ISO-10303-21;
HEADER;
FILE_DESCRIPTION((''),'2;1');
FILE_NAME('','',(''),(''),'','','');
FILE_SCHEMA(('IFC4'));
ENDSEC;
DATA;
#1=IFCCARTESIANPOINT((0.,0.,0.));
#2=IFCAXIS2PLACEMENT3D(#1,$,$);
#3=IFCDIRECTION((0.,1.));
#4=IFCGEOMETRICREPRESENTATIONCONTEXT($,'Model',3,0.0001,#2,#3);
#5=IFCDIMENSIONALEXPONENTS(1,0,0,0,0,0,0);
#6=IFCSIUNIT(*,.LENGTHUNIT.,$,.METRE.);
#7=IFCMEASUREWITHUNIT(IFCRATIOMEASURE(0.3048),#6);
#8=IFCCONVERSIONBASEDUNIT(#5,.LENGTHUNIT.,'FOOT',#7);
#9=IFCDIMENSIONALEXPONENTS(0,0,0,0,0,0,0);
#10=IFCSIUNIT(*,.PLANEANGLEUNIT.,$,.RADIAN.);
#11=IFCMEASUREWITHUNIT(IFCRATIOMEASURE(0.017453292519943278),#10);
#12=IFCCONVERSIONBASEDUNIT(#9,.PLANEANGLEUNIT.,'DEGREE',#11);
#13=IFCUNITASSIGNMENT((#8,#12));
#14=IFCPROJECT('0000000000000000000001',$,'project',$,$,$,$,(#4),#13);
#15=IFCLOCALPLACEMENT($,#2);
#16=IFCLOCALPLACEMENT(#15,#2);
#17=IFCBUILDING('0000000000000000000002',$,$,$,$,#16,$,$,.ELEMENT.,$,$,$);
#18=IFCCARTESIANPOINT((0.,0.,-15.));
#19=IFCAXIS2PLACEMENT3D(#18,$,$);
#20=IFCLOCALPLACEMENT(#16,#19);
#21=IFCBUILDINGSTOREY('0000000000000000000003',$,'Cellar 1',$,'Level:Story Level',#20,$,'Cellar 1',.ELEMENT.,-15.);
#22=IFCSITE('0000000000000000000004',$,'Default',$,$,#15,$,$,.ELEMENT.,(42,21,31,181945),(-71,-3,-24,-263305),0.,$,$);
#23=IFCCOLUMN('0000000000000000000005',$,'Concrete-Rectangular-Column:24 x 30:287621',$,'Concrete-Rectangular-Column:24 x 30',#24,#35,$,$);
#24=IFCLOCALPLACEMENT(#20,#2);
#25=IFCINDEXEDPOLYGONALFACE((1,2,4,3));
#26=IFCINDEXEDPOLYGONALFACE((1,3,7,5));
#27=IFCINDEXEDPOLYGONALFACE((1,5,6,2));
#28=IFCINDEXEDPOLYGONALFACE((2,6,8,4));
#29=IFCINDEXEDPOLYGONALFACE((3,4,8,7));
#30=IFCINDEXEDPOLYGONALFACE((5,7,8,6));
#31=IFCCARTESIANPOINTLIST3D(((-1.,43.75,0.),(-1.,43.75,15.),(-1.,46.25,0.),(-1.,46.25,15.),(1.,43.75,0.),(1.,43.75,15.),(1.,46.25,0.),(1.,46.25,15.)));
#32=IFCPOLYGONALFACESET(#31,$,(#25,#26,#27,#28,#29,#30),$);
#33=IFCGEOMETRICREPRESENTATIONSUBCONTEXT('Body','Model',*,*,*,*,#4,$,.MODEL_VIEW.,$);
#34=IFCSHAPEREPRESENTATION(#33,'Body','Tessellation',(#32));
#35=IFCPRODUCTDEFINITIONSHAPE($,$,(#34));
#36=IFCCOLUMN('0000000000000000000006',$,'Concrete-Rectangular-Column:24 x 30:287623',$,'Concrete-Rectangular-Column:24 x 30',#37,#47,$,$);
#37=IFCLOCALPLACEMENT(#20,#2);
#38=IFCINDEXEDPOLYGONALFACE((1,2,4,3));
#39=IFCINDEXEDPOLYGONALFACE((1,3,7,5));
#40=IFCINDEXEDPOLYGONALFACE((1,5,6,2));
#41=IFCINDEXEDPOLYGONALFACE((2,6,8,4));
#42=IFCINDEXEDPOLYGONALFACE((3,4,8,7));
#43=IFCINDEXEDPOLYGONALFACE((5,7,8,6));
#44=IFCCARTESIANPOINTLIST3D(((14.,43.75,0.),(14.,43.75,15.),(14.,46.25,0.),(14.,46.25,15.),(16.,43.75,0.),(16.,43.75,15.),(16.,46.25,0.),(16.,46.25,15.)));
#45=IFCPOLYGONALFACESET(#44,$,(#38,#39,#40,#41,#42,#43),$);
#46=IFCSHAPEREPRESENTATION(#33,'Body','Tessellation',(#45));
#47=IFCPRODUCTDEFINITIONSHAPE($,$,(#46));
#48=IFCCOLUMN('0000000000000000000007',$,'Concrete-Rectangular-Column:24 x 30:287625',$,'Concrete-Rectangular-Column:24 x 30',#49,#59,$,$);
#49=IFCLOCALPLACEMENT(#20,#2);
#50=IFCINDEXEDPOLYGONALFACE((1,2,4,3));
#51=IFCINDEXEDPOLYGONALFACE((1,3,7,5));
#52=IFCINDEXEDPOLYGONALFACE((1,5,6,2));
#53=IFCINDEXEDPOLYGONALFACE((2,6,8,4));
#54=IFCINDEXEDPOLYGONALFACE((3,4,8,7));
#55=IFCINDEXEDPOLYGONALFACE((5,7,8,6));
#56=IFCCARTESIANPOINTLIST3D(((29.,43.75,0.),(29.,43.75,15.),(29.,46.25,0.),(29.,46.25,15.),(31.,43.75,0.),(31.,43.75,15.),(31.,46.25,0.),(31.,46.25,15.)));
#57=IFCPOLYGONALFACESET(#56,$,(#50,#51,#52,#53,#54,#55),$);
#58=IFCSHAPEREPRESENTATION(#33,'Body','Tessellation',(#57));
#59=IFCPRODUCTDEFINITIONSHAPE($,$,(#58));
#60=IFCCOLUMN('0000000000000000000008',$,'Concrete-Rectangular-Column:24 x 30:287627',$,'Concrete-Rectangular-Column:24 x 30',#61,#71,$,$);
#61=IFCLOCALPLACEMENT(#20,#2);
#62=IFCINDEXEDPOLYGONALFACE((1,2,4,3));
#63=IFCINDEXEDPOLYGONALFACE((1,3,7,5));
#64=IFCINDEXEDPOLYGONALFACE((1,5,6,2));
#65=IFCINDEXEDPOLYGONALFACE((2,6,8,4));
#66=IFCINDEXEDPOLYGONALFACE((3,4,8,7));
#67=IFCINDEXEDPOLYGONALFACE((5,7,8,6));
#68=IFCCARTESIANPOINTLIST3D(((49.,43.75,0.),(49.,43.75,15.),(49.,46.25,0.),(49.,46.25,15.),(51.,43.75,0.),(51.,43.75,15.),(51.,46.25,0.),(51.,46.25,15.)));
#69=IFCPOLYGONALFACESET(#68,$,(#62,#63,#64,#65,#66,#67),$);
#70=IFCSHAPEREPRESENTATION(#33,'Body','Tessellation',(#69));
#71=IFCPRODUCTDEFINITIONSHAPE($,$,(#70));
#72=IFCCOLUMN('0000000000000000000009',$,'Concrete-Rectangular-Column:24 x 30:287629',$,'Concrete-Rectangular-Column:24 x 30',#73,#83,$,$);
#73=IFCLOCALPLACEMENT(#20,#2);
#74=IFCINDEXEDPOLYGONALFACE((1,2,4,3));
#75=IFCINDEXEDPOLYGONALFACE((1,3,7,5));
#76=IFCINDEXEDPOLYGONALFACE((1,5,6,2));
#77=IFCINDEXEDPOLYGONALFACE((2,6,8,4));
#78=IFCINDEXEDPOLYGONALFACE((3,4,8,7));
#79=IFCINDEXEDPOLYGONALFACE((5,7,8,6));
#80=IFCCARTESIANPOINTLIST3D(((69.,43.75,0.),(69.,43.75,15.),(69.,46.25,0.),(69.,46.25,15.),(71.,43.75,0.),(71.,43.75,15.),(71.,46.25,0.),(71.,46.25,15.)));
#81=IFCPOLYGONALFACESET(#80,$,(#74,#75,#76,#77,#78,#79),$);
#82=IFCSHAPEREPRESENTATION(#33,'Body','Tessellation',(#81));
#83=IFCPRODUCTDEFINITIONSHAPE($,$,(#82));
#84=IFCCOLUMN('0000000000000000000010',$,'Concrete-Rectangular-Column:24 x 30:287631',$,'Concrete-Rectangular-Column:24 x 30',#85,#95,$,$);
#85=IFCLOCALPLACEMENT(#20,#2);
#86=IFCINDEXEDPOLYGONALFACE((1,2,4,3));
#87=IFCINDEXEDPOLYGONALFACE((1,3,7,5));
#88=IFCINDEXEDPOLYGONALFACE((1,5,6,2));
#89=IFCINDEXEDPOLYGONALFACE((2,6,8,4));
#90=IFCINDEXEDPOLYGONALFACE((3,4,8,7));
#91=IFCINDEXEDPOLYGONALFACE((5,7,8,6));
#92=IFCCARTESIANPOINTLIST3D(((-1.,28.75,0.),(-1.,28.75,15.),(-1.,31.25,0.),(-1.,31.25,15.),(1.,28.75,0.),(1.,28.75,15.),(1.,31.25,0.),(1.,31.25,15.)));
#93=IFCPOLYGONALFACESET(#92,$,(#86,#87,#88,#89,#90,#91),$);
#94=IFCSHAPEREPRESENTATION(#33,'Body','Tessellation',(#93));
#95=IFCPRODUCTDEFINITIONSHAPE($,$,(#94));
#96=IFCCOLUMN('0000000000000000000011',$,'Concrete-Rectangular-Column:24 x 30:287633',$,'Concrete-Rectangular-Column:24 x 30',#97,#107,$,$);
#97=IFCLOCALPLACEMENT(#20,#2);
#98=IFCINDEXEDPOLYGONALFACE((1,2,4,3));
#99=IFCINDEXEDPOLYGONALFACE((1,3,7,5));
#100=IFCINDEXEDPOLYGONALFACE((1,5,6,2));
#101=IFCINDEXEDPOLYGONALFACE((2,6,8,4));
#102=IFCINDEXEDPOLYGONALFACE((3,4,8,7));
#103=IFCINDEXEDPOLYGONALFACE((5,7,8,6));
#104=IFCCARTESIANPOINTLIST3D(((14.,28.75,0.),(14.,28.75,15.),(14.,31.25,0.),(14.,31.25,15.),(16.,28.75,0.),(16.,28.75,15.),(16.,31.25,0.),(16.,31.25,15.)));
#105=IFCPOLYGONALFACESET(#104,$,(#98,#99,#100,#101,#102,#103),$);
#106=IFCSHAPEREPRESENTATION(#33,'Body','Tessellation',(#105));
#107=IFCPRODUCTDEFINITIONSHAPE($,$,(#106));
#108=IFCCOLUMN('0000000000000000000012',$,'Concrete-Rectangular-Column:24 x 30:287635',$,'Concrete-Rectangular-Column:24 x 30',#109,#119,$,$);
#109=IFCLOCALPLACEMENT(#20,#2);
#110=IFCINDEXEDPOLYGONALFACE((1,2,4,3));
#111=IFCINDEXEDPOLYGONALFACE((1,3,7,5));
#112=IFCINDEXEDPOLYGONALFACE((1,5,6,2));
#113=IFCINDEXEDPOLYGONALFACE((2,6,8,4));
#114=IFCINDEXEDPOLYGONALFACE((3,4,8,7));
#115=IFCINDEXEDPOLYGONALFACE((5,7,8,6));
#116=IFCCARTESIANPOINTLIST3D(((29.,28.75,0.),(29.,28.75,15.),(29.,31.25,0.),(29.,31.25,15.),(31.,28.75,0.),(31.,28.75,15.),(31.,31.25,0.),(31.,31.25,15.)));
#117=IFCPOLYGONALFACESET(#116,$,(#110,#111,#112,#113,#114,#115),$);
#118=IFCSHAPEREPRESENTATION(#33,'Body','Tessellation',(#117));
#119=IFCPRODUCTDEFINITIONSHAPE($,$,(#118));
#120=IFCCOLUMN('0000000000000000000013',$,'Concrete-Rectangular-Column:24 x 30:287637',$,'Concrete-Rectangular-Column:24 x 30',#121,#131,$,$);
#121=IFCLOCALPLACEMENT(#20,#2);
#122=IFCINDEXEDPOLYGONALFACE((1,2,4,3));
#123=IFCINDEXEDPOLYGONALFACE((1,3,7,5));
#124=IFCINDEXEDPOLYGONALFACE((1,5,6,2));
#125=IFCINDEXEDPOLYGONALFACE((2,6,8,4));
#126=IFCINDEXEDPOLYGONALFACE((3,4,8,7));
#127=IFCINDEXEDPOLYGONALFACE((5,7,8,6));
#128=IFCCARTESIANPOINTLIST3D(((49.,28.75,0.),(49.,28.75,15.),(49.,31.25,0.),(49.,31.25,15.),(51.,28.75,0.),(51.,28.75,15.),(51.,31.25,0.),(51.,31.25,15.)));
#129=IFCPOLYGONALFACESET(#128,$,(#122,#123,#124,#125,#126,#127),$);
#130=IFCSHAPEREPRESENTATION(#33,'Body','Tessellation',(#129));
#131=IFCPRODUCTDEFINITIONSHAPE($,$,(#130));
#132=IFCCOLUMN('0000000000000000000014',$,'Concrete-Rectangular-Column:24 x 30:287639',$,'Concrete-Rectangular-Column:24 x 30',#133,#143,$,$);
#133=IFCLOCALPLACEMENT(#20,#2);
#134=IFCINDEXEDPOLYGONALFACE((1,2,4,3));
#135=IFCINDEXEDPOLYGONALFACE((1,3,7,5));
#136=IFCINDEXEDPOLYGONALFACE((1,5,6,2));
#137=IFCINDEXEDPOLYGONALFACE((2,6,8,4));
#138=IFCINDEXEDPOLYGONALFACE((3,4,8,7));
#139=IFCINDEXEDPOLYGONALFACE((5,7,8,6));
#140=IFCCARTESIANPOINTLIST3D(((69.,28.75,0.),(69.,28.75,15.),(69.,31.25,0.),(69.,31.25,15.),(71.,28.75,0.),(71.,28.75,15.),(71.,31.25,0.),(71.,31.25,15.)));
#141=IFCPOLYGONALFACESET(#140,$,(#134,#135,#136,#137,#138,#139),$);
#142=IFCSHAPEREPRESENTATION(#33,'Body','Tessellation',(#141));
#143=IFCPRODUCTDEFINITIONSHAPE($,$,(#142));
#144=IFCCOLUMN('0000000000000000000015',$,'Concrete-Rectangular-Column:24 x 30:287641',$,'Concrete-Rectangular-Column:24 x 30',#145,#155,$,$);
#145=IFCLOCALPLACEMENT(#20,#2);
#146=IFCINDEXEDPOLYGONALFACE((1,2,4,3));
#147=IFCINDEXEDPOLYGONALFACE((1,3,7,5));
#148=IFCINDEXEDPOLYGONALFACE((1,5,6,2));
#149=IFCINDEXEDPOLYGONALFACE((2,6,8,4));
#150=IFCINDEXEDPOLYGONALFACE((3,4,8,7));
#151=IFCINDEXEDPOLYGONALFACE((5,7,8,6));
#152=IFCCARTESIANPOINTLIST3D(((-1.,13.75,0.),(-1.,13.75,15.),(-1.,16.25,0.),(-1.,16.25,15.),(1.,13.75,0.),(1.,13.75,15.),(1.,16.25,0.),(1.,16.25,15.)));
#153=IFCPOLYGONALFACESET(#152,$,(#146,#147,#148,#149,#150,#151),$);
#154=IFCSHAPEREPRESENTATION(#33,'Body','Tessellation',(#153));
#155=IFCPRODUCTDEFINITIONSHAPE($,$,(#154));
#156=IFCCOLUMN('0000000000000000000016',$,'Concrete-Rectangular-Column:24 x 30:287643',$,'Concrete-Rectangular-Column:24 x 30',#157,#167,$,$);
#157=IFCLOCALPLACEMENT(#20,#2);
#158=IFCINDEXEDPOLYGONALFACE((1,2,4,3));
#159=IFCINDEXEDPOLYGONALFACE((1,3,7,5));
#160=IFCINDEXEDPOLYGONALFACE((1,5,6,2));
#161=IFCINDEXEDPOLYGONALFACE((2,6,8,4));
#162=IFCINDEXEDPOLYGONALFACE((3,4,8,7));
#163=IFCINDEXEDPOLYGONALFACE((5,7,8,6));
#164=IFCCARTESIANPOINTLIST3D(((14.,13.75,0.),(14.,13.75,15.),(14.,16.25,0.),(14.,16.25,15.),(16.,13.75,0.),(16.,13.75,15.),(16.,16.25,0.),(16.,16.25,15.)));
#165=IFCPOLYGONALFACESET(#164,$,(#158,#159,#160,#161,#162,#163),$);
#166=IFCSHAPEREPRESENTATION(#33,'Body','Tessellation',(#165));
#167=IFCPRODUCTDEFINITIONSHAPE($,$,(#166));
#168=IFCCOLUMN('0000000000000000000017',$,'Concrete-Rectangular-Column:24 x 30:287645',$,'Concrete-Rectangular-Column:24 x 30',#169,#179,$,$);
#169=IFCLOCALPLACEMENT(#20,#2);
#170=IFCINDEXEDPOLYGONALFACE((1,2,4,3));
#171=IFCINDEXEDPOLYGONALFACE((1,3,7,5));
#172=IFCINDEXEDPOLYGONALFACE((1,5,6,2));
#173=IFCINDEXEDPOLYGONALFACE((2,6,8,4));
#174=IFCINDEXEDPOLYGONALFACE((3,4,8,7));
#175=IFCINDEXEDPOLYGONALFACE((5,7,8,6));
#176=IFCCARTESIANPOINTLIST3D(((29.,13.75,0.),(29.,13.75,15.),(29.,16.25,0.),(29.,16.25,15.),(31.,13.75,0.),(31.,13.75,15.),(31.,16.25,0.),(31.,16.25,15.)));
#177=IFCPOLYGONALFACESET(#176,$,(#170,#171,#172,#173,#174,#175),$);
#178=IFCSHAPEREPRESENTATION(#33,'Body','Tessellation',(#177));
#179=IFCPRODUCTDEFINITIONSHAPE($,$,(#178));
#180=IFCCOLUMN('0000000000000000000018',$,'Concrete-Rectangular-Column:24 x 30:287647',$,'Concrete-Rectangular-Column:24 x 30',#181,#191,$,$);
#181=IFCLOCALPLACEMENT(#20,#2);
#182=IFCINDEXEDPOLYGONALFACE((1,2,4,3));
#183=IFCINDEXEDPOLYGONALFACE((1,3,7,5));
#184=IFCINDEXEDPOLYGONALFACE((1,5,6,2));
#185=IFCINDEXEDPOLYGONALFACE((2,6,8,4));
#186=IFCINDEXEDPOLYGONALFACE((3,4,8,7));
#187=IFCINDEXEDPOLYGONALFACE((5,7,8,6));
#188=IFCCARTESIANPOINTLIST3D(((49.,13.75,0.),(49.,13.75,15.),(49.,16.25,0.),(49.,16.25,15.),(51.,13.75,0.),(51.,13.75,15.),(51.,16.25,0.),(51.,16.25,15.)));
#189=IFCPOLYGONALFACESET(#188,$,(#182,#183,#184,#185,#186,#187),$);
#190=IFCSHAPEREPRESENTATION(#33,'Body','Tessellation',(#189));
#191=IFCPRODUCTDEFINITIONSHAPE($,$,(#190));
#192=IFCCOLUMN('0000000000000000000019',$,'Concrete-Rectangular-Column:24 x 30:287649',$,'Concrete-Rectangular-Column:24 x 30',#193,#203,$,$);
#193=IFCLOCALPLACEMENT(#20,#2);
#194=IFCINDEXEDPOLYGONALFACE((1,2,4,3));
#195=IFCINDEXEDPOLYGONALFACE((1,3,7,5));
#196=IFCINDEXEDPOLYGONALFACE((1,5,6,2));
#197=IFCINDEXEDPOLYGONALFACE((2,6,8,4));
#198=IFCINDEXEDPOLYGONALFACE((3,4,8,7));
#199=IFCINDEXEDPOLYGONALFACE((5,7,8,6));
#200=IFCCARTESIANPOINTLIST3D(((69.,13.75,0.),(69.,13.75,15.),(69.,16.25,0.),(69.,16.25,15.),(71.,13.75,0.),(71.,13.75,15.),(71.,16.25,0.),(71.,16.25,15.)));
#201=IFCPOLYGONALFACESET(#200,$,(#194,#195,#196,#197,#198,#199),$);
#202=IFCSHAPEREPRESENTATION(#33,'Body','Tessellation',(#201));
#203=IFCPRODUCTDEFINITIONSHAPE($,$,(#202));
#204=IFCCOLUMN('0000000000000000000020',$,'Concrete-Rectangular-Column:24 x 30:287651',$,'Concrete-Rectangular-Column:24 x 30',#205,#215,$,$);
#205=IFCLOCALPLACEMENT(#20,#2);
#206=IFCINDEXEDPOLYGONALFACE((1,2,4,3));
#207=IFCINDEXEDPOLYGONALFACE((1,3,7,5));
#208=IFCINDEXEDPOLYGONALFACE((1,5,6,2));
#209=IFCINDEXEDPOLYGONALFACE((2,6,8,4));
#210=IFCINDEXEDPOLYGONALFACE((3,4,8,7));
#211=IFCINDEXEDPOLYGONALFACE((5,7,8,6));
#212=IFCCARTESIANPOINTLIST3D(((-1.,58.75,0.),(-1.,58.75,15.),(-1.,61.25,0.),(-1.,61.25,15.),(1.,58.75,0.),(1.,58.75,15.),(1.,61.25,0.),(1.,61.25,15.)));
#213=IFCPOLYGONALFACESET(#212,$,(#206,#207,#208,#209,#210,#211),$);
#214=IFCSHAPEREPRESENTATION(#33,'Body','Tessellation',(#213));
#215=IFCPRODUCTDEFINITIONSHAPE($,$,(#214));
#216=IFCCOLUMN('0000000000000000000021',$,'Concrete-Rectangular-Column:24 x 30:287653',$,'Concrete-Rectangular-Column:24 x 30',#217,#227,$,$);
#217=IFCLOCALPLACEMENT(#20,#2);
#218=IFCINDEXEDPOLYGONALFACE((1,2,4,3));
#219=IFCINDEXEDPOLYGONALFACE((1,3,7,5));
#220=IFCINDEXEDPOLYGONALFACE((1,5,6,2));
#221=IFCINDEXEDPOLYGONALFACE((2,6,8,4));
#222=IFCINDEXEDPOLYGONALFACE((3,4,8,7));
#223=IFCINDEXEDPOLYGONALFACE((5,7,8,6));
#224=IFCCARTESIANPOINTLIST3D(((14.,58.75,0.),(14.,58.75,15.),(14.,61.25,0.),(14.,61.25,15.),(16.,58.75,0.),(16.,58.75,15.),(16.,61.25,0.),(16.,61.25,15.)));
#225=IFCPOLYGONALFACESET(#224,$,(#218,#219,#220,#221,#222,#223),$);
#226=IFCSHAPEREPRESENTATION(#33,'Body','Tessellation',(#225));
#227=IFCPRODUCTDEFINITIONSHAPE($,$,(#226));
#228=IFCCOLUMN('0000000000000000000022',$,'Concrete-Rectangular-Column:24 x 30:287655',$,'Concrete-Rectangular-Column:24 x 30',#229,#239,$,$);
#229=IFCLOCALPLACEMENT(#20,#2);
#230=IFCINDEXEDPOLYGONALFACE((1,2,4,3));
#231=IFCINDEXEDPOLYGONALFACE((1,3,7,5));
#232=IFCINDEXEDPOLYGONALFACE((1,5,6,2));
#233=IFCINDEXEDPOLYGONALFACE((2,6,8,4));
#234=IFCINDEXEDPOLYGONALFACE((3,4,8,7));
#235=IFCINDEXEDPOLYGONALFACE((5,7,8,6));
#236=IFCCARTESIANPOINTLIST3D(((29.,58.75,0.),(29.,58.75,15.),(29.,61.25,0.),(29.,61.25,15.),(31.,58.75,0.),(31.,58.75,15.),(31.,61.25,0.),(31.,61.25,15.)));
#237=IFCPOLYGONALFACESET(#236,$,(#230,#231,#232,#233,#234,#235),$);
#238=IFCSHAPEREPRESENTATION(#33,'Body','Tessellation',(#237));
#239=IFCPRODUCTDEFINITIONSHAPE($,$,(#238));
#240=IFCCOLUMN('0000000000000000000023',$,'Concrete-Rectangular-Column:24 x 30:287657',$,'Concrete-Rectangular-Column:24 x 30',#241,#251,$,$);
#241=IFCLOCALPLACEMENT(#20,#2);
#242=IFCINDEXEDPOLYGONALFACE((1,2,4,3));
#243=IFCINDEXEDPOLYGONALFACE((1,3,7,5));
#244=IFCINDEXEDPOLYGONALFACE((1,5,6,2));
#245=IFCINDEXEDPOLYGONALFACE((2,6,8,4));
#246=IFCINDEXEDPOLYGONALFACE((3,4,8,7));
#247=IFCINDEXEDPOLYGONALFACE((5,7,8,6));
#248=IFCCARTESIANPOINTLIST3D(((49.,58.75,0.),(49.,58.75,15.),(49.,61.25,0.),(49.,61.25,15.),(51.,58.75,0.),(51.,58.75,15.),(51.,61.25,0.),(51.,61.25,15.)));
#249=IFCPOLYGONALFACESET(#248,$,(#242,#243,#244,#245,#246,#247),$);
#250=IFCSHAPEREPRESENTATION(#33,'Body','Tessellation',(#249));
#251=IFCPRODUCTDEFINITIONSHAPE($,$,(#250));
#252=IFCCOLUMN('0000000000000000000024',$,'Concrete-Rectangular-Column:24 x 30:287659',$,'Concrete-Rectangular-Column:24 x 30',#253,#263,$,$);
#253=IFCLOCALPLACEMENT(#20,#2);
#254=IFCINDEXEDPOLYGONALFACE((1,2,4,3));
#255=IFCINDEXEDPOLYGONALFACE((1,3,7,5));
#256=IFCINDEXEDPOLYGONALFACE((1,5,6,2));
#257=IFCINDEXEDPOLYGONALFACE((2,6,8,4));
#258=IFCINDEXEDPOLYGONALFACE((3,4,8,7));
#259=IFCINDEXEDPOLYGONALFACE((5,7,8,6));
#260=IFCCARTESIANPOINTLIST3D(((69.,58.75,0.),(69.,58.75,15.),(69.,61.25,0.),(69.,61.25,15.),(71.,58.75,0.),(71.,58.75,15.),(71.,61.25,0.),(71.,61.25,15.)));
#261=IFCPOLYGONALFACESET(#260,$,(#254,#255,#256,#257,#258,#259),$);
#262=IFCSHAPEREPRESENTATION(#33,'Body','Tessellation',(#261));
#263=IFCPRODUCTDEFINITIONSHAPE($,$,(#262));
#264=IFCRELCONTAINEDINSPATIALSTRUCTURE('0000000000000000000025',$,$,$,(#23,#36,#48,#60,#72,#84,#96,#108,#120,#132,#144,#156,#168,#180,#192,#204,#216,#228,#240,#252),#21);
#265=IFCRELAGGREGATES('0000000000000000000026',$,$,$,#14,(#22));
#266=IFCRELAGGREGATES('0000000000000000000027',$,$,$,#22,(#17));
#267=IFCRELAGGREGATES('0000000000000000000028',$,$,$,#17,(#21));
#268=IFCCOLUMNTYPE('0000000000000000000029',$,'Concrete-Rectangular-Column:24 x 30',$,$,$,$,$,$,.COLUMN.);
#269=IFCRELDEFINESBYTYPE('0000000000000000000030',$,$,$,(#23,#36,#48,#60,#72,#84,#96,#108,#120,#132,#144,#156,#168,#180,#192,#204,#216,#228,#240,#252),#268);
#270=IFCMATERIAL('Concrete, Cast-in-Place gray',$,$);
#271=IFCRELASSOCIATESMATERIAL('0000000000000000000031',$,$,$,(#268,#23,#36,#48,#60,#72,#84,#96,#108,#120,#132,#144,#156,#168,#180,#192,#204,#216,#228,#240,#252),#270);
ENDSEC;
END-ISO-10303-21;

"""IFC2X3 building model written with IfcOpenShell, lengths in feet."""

from ifc_helpers import new_model, entity, si_unit, converted_unit, direction, frame, origin, origin_2d_with_axis, place, context, subcontext, project, spatial, rectangle, extrude, source, transform, mapped, material, type_object, type_shapes, element, save


model = new_model("IFC2X3")

# Units and contexts
model_context = context("Model", 3, precision=0.0001, world=origin(), true_north=direction((0.0, 1.0)))
body_context = subcontext(model_context, "Body", "Model", "MODEL_VIEW")
ifc_project = project(units=[converted_unit("LENGTHUNIT", "FOOT", entity("IfcRatioMeasure", 0.3048), si_unit("LENGTHUNIT", "METRE"), dimensions=[1, 0, 0, 0, 0, 0, 0]), converted_unit("PLANEANGLEUNIT", "DEGREE", entity("IfcRatioMeasure", 0.017453292519943278), si_unit("PLANEANGLEUNIT", "RADIAN"), dimensions=[0, 0, 0, 0, 0, 0, 0])], contexts=[model_context])

# Site, building, storey
site_placement = place(None, origin())
site = spatial("IfcSite", under=ifc_project, at=site_placement, Name="Default", CompositionType="ELEMENT", RefLatitude=(42, 21, 31, 181945), RefLongitude=(-71, -3, -24, -263305), RefElevation=0.0)
building_placement = place(site_placement, origin())
building = spatial("IfcBuilding", under=site, at=building_placement, CompositionType="ELEMENT")
storey_placement = place(building_placement, frame((0.0, 0.0, -15.0)))
storey = spatial("IfcBuildingStorey", under=building, at=storey_placement, Name="Cellar 1", ObjectType="Level:Story Level", LongName="Cellar 1", CompositionType="ELEMENT", Elevation=-15.0)

# Columns
ifc_material = material(Name="Concrete, Cast-in-Place gray")
column_type = type_object("IfcColumnType", Name="Concrete-Rectangular-Column:24 x 30", PredefinedType="COLUMN", material=ifc_material)
shared_shape = source(origin(), body_context, "Body", "SweptSolid", [
    extrude(rectangle(XDim=2.5, YDim=2.0, at=origin_2d_with_axis()), frame((0.0, 0.0, -15.0), z_axis=(0.0, 0.0, 1.0), x_axis=(0.0, -1.0, 0.0)), (0.0, 0.0, 1.0), 15.0),
])
type_shapes(column_type, [shared_shape])
for number, where, name in (
    (1, (0.0, 45.0, 15.0), "Concrete-Rectangular-Column:24 x 30:287621"),
    (2, (15.0, 45.0, 15.0), "Concrete-Rectangular-Column:24 x 30:287623"),
    (3, (30.0, 45.0, 15.0), "Concrete-Rectangular-Column:24 x 30:287625"),
    (4, (50.0, 45.0, 15.0), "Concrete-Rectangular-Column:24 x 30:287627"),
    (5, (70.0, 45.0, 15.0), "Concrete-Rectangular-Column:24 x 30:287629"),
    (6, (0.0, 30.0, 15.0), "Concrete-Rectangular-Column:24 x 30:287631"),
    (7, (15.0, 30.0, 15.0), "Concrete-Rectangular-Column:24 x 30:287633"),
    (8, (30.0, 30.0, 15.0), "Concrete-Rectangular-Column:24 x 30:287635"),
    (9, (50.0, 30.0, 15.0), "Concrete-Rectangular-Column:24 x 30:287637"),
    (10, (70.0, 30.0, 15.0), "Concrete-Rectangular-Column:24 x 30:287639"),
    (11, (0.0, 15.0, 15.0), "Concrete-Rectangular-Column:24 x 30:287641"),
    (12, (15.0, 15.0, 15.0), "Concrete-Rectangular-Column:24 x 30:287643"),
    (13, (30.0, 15.0, 15.0), "Concrete-Rectangular-Column:24 x 30:287645"),
    (14, (50.0, 15.0, 15.0), "Concrete-Rectangular-Column:24 x 30:287647"),
    (15, (70.0, 15.0, 15.0), "Concrete-Rectangular-Column:24 x 30:287649"),
    (16, (0.0, 60.0, 15.0), "Concrete-Rectangular-Column:24 x 30:287651"),
    (17, (15.0, 60.0, 15.0), "Concrete-Rectangular-Column:24 x 30:287653"),
    (18, (30.0, 60.0, 15.0), "Concrete-Rectangular-Column:24 x 30:287655"),
    (19, (50.0, 60.0, 15.0), "Concrete-Rectangular-Column:24 x 30:287657"),
    (20, (70.0, 60.0, 15.0), "Concrete-Rectangular-Column:24 x 30:287659"),
):
    element("IfcColumn", number, at=place(storey_placement, frame(where)), inside=storey, type_object=column_type, material=ifc_material, Name=name, ObjectType="Concrete-Rectangular-Column:24 x 30", context=body_context, shape_type="MappedRepresentation", body=[
        mapped(shared_shape, transform((0.0, 0.0, 0.0), scale=1.0)),
    ])

save(model, "model.ifc")
